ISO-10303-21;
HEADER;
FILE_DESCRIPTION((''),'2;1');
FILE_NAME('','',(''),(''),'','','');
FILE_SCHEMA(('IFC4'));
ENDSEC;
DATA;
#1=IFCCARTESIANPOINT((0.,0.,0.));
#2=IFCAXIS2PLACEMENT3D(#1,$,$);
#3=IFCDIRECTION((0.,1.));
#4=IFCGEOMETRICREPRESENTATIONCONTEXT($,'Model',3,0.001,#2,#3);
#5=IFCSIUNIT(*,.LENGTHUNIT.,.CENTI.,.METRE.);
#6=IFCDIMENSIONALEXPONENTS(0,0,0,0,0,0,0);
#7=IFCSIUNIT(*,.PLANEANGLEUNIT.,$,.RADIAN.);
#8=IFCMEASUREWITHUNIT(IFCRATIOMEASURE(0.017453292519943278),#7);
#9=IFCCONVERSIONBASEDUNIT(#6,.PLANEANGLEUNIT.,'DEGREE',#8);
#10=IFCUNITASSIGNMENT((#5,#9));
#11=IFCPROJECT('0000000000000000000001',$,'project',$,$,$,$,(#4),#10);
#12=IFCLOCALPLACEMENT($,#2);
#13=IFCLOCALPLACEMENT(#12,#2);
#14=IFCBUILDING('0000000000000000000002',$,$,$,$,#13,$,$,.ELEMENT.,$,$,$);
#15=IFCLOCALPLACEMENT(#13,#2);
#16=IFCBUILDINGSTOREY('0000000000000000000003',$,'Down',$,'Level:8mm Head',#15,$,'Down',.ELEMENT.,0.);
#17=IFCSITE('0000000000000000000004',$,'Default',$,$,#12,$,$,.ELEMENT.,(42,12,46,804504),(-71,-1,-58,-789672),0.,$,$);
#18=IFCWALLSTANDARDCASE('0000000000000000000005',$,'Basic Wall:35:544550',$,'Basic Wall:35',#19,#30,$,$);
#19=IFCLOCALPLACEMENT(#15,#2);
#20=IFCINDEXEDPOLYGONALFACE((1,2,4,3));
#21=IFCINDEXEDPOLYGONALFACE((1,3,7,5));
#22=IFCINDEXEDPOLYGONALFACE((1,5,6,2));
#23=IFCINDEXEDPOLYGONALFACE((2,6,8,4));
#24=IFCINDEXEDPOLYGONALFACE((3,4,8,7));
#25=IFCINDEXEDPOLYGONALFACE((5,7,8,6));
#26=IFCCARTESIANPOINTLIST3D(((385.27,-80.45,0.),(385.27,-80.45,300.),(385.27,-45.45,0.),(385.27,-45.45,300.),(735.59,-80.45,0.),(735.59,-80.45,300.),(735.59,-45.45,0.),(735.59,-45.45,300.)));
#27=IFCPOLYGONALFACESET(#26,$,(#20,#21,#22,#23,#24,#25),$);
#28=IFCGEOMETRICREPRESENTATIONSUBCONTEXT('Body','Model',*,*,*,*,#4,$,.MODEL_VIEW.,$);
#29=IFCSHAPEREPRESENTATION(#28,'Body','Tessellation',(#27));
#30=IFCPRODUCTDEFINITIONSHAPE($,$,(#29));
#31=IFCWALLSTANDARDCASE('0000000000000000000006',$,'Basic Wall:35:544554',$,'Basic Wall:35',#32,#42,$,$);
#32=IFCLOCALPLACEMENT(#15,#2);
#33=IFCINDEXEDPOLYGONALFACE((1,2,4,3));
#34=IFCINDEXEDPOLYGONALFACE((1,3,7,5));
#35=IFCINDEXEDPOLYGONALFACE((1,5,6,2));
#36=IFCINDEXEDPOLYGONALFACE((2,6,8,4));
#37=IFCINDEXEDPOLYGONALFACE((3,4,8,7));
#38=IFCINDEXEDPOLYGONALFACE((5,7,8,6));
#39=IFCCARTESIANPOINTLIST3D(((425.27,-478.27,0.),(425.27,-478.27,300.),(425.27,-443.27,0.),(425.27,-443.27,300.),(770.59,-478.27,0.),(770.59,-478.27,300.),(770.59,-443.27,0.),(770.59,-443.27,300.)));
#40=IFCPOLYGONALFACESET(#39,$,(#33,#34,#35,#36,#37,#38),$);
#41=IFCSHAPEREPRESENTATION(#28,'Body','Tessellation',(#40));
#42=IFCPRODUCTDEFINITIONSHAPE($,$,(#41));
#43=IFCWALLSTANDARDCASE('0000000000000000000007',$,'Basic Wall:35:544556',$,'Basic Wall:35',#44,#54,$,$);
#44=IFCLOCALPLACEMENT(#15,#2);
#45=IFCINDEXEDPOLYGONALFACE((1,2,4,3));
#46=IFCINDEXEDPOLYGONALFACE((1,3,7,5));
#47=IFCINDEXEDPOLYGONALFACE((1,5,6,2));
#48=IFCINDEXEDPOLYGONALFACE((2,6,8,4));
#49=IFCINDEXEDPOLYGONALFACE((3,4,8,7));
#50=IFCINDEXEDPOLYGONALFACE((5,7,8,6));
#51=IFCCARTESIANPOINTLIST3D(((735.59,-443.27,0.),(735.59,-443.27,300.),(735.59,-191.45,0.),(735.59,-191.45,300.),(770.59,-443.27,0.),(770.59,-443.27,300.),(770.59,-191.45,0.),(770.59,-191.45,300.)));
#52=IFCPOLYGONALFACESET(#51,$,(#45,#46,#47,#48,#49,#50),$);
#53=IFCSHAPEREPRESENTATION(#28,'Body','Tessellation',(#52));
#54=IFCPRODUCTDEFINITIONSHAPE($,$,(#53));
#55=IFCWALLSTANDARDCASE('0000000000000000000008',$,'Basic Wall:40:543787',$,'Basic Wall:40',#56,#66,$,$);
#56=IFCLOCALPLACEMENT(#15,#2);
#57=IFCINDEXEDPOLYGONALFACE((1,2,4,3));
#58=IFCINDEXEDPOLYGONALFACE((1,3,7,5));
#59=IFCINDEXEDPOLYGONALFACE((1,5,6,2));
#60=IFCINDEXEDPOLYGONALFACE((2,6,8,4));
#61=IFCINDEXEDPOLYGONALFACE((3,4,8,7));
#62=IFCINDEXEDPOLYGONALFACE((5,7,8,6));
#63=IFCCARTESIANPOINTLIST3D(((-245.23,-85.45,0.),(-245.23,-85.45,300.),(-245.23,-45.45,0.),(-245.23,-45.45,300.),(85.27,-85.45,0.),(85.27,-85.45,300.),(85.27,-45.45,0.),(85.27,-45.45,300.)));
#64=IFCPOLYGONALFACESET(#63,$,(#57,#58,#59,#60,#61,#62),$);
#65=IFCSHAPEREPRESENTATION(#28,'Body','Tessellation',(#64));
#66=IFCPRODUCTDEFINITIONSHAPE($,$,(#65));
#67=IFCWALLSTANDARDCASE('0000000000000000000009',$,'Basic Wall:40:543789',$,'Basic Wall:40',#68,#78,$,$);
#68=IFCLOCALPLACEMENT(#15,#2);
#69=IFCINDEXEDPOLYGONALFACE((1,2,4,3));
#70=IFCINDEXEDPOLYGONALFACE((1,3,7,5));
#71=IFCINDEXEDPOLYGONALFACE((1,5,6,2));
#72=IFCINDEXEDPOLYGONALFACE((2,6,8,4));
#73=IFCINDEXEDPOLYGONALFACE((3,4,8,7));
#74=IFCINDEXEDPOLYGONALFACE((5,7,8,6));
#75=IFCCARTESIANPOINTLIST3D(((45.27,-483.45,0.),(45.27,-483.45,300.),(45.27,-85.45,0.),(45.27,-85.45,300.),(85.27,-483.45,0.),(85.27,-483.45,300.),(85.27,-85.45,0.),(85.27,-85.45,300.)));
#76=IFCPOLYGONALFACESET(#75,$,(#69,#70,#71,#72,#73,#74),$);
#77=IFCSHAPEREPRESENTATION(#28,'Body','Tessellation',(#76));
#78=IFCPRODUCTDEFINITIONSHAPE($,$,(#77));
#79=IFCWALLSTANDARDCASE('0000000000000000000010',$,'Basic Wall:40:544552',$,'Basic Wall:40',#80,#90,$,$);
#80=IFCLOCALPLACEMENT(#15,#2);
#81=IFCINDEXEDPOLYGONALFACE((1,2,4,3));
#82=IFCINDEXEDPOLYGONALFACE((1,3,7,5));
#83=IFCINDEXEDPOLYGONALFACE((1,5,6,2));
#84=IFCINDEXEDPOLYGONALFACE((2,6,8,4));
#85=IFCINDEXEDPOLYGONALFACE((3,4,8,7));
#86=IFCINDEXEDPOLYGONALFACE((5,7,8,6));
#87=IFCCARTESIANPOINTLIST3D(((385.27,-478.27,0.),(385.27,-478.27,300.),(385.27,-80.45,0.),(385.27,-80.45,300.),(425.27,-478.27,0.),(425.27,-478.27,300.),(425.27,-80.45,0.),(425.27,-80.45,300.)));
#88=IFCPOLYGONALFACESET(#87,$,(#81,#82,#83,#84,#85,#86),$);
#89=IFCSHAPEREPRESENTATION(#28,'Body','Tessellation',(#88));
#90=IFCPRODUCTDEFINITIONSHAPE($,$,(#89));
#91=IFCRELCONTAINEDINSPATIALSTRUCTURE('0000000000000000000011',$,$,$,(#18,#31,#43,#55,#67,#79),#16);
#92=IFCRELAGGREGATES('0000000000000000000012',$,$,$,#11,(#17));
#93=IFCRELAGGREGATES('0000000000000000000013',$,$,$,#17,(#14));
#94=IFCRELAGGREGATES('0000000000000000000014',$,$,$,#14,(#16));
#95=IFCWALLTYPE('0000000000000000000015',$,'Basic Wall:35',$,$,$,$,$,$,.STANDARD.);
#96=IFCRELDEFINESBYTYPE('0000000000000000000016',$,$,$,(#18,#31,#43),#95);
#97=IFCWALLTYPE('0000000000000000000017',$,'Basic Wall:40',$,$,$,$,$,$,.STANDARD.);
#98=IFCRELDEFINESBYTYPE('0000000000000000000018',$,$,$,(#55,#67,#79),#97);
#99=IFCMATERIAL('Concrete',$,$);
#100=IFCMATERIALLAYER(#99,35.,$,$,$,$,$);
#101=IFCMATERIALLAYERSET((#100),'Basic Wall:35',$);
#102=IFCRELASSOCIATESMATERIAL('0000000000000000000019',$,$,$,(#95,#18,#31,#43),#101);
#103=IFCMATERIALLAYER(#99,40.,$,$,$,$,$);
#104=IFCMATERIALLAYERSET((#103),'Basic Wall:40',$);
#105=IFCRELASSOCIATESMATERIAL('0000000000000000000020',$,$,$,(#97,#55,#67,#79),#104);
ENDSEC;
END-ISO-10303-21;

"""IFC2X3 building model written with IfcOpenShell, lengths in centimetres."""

from ifc_helpers import new_model, entity, si_unit, converted_unit, direction, frame, frame_2d, origin, place, context, subcontext, project, spatial, rectangle, extrude, material, layer, layer_set, layer_usage, type_object, element, save


model = new_model("IFC2X3")

# Units and contexts
model_context = context("Model", 3, precision=0.001, world=origin(), true_north=direction((0.0, 1.0)))
body_context = subcontext(model_context, "Body", "Model", "MODEL_VIEW")
ifc_project = project(units=[si_unit("LENGTHUNIT", "METRE", prefix="CENTI"), converted_unit("PLANEANGLEUNIT", "DEGREE", entity("IfcRatioMeasure", 0.017453292519943278), si_unit("PLANEANGLEUNIT", "RADIAN"), dimensions=[0, 0, 0, 0, 0, 0, 0])], contexts=[model_context])

# Site, building, storey
site_placement = place(None, origin())
site = spatial("IfcSite", under=ifc_project, at=site_placement, Name="Default", CompositionType="ELEMENT", RefLatitude=(42, 12, 46, 804504), RefLongitude=(-71, -1, -58, -789672), RefElevation=0.0)
building_placement = place(site_placement, origin())
building = spatial("IfcBuilding", under=site, at=building_placement, CompositionType="ELEMENT")
storey_placement = place(building_placement, origin())
storey = spatial("IfcBuildingStorey", under=building, at=storey_placement, Name="Down", ObjectType="Level:8mm Head", LongName="Down", CompositionType="ELEMENT", Elevation=0.0)

# Shared definitions
ifc_material = material(Name="Concrete")

# Walls
ifc_layer_1 = layer(ifc_material, 35.0)
ifc_layer_set_1 = layer_set([ifc_layer_1], Name="Basic Wall:35")
wall_type_1 = type_object("IfcWallType", Name="Basic Wall:35", PredefinedType="STANDARD", material=ifc_layer_set_1)
ifc_layer_usage_1 = layer_usage(ifc_layer_set_1, "AXIS2", "POSITIVE", -17.5)
wall_1_placement = place(storey_placement, frame((735.59, -62.95, 0.0), z_axis=(0.0, 0.0, 1.0), x_axis=(-1.0, 0.0, 0.0)))
element("IfcWallStandardCase", 1, at=wall_1_placement, inside=storey, type_object=wall_type_1, material=ifc_layer_usage_1, Name="Basic Wall:35:544550", ObjectType="Basic Wall:35", context=body_context, shape_type="SweptSolid", body=[
    extrude(rectangle(XDim=350.32, YDim=35.0, at=frame_2d((175.16, 0.0), x_axis=(-1.0, 0.0))), origin(), (0.0, 0.0, 1.0), 300.0),
])
ifc_layer_usage_2 = layer_usage(ifc_layer_set_1, "AXIS2", "POSITIVE", -17.5)
wall_2_placement = place(storey_placement, frame((425.27, -460.77, 0.0)))
element("IfcWallStandardCase", 2, at=wall_2_placement, inside=storey, type_object=wall_type_1, material=ifc_layer_usage_2, Name="Basic Wall:35:544554", ObjectType="Basic Wall:35", context=body_context, shape_type="SweptSolid", body=[
    extrude(rectangle(XDim=345.32, YDim=35.0, at=frame_2d((172.66, 0.0), x_axis=(-1.0, 0.0))), origin(), (0.0, 0.0, 1.0), 300.0),
])
ifc_layer_usage_3 = layer_usage(ifc_layer_set_1, "AXIS2", "POSITIVE", -17.5)
wall_3_placement = place(storey_placement, frame((753.09, -443.27, 0.0), z_axis=(0.0, 0.0, 1.0), x_axis=(0.0, 1.0, 0.0)))
element("IfcWallStandardCase", 3, at=wall_3_placement, inside=storey, type_object=wall_type_1, material=ifc_layer_usage_3, Name="Basic Wall:35:544556", ObjectType="Basic Wall:35", context=body_context, shape_type="SweptSolid", body=[
    extrude(rectangle(XDim=251.82, YDim=35.0, at=frame_2d((125.91, 0.0), x_axis=(-1.0, 0.0))), origin(), (0.0, 0.0, 1.0), 300.0),
])
ifc_layer_2 = layer(ifc_material, 40.0)
ifc_layer_set_2 = layer_set([ifc_layer_2], Name="Basic Wall:40")
ifc_layer_usage_4 = layer_usage(ifc_layer_set_2, "AXIS2", "NEGATIVE", 20.0)
wall_type_2 = type_object("IfcWallType", Name="Basic Wall:40", PredefinedType="STANDARD", material=ifc_layer_set_2)
wall_4_placement = place(storey_placement, frame((-245.23, -65.45, 0.0)))
element("IfcWallStandardCase", 4, at=wall_4_placement, inside=storey, type_object=wall_type_2, material=ifc_layer_usage_4, Name="Basic Wall:40:543787", ObjectType="Basic Wall:40", context=body_context, shape_type="SweptSolid", body=[
    extrude(rectangle(XDim=330.5, YDim=40.0, at=frame_2d((165.25, 0.0), x_axis=(-1.0, 0.0))), origin(), (0.0, 0.0, 1.0), 300.0),
])
ifc_layer_usage_5 = layer_usage(ifc_layer_set_2, "AXIS2", "NEGATIVE", 20.0)
wall_5_placement = place(storey_placement, frame((65.27, -85.45, 0.0), z_axis=(0.0, 0.0, 1.0), x_axis=(0.0, -1.0, 0.0)))
element("IfcWallStandardCase", 5, at=wall_5_placement, inside=storey, type_object=wall_type_2, material=ifc_layer_usage_5, Name="Basic Wall:40:543789", ObjectType="Basic Wall:40", context=body_context, shape_type="SweptSolid", body=[
    extrude(rectangle(XDim=398.0, YDim=40.0, at=frame_2d((199.0, 0.0), x_axis=(-1.0, 0.0))), origin(), (0.0, 0.0, 1.0), 300.0),
])
ifc_layer_usage_6 = layer_usage(ifc_layer_set_2, "AXIS2", "POSITIVE", -20.0)
wall_6_placement = place(storey_placement, frame((405.27, -80.45, 0.0), z_axis=(0.0, 0.0, 1.0), x_axis=(0.0, -1.0, 0.0)))
element("IfcWallStandardCase", 6, at=wall_6_placement, inside=storey, type_object=wall_type_2, material=ifc_layer_usage_6, Name="Basic Wall:40:544552", ObjectType="Basic Wall:40", context=body_context, shape_type="SweptSolid", body=[
    extrude(rectangle(XDim=397.82, YDim=40.0, at=frame_2d((198.91, 0.0), x_axis=(-1.0, 0.0))), origin(), (0.0, 0.0, 1.0), 300.0),
])

save(model, "model.ifc")
